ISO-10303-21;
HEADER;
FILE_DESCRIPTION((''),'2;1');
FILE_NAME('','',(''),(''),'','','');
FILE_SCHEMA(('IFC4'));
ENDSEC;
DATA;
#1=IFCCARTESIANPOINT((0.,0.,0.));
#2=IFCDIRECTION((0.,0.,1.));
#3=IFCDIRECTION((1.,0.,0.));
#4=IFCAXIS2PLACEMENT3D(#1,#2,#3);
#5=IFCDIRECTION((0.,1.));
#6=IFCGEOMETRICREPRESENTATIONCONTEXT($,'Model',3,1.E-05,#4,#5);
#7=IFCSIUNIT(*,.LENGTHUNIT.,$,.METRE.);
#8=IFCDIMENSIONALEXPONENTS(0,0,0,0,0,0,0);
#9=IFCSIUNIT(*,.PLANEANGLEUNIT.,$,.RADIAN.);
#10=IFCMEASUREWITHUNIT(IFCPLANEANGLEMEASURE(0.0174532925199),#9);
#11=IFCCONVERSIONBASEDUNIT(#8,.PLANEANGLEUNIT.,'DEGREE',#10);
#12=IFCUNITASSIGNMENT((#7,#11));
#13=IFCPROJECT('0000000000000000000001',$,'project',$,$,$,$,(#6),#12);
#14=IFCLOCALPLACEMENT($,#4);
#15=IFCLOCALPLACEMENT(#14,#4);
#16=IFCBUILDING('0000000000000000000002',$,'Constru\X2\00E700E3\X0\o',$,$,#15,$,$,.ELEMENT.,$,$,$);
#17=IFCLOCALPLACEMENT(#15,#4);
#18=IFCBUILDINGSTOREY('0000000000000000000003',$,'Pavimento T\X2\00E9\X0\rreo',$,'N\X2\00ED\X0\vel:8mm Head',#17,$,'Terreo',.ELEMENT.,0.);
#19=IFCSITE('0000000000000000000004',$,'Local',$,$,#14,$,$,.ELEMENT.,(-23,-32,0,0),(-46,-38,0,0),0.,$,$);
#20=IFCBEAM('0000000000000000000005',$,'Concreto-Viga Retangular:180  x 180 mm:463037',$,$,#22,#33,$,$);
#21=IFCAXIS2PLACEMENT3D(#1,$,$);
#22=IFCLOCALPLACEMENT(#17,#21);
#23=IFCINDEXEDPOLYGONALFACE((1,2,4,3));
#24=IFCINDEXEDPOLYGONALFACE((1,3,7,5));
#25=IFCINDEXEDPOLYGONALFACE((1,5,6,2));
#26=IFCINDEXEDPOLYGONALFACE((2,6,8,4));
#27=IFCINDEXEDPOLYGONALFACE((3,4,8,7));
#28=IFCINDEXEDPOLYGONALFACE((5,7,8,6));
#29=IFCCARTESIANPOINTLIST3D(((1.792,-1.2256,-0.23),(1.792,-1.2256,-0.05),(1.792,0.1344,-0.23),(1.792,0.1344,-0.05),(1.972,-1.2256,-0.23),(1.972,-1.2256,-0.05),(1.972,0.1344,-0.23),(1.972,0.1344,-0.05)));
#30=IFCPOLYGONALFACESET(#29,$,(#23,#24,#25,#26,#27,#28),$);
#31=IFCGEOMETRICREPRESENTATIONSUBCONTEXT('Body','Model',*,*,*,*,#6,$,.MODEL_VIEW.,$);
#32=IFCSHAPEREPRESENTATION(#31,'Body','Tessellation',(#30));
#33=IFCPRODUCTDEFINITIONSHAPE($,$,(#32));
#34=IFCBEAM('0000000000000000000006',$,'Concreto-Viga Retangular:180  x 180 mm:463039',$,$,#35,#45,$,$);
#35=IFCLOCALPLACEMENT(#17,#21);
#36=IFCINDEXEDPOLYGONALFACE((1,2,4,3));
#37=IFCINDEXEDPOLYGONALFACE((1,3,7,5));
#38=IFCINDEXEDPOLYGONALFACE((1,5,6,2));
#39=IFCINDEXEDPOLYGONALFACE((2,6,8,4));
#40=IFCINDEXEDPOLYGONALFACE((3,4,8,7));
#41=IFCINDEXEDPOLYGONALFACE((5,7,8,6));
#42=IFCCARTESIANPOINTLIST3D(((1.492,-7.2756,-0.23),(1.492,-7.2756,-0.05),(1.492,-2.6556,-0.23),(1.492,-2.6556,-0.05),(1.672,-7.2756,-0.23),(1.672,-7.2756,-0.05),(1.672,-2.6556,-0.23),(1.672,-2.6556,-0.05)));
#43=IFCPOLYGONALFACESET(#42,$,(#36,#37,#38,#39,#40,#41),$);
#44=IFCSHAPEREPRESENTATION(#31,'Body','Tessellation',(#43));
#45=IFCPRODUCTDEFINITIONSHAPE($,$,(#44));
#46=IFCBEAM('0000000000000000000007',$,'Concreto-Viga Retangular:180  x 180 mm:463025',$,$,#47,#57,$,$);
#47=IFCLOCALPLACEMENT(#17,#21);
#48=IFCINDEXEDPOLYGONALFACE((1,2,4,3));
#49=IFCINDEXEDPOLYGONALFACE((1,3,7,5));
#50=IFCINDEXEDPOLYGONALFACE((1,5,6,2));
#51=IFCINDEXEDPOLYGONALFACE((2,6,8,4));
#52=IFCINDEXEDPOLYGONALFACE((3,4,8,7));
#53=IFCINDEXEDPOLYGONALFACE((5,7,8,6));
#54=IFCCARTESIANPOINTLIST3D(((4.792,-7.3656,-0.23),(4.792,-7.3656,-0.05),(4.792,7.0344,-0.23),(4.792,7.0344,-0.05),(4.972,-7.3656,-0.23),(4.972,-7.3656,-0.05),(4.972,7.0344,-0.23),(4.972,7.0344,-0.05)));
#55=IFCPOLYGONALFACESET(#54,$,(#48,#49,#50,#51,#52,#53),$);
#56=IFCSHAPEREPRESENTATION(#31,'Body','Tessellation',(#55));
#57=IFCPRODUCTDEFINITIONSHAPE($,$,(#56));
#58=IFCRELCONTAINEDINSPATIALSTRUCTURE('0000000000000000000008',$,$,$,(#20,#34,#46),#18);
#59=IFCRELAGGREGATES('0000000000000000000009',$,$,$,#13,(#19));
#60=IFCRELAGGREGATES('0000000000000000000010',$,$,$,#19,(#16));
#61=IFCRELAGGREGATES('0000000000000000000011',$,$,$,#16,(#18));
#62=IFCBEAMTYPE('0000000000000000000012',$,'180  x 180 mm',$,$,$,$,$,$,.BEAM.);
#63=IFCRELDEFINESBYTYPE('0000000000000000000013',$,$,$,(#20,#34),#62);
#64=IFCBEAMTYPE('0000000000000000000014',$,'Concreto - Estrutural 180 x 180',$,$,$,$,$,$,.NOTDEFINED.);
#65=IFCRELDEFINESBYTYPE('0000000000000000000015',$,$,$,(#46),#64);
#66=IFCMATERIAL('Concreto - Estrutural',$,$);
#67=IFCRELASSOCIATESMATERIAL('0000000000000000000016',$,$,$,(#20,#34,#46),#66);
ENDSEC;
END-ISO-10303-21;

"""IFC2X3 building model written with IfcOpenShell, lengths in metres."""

from ifc_helpers import new_model, entity, si_unit, converted_unit, direction, frame, frame_2d, origin_with_axes, place, context, subcontext, project, spatial, rectangle, extrude, material, type_object, element, save


model = new_model("IFC2X3")

# Units and contexts
model_context = context("Model", 3, precision=1e-05, world=origin_with_axes(), true_north=direction((0.0, 1.0)))
body_context = subcontext(model_context, "Body", "Model", "MODEL_VIEW")
ifc_project = project(units=[si_unit("LENGTHUNIT", "METRE"), converted_unit("PLANEANGLEUNIT", "DEGREE", entity("IfcPlaneAngleMeasure", 0.0174532925199), si_unit("PLANEANGLEUNIT", "RADIAN"), dimensions=[0, 0, 0, 0, 0, 0, 0])], contexts=[model_context])

# Site, building, storey
site_placement = place(None, origin_with_axes())
site = spatial("IfcSite", under=ifc_project, at=site_placement, Name="Local", CompositionType="ELEMENT", RefLatitude=(-23, -32, 0, 0), RefLongitude=(-46, -38, 0, 0), RefElevation=0.0)
building_placement = place(site_placement, origin_with_axes())
building = spatial("IfcBuilding", under=site, at=building_placement, Name="Construção", CompositionType="ELEMENT")
storey_placement = place(building_placement, origin_with_axes())
storey = spatial("IfcBuildingStorey", under=building, at=storey_placement, Name="Pavimento Térreo", ObjectType="Nível:8mm Head", LongName="Terreo", CompositionType="ELEMENT", Elevation=0.0)

# Shared definitions
ifc_material = material(Name="Concreto - Estrutural")

# Beams
beam_type_1 = type_object("IfcBeamType", Name="180  x 180 mm", PredefinedType="BEAM")
beam_1_placement = place(storey_placement, frame((1.882, -1.2256, -0.05), z_axis=(0.0, 0.0, 1.0), x_axis=(1.0, 0.0, 0.0)))
element("IfcBeam", 1, at=beam_1_placement, inside=storey, type_object=beam_type_1, material=ifc_material, Name="Concreto-Viga Retangular:180  x 180 mm:463037", context=body_context, shape_type="SweptSolid", body=[
    extrude(rectangle(XDim=0.18, YDim=0.18, at=frame_2d((-0.09, 0.0), x_axis=(1.0, 0.0))), frame((0.0, 0.0, 0.0), z_axis=(0.0, 1.0, 0.0), x_axis=(0.0, 0.0, 1.0)), (0.0, 0.0, 1.0), 1.36),
])
beam_2_placement = place(storey_placement, frame((1.582, -7.2756, -0.05), z_axis=(0.0, 0.0, 1.0), x_axis=(1.0, 0.0, 0.0)))
element("IfcBeam", 2, at=beam_2_placement, inside=storey, type_object=beam_type_1, material=ifc_material, Name="Concreto-Viga Retangular:180  x 180 mm:463039", context=body_context, shape_type="SweptSolid", body=[
    extrude(rectangle(XDim=0.18, YDim=0.18, at=frame_2d((-0.09, 0.0), x_axis=(1.0, 0.0))), frame((0.0, 0.0, 0.0), z_axis=(0.0, 1.0, 0.0), x_axis=(0.0, 0.0, 1.0)), (0.0, 0.0, 1.0), 4.62),
])
beam_type_2 = type_object("IfcBeamType", Name="Concreto - Estrutural 180 x 180", PredefinedType="NOTDEFINED")
beam_3_placement = place(storey_placement, frame((4.882, -7.3656, -0.05), z_axis=(0.0, 0.0, 1.0), x_axis=(1.0, 0.0, 0.0)))
element("IfcBeam", 3, at=beam_3_placement, inside=storey, type_object=beam_type_2, material=ifc_material, Name="Concreto-Viga Retangular:180  x 180 mm:463025", context=body_context, shape_type="SweptSolid", body=[
    extrude(rectangle(XDim=0.18, YDim=0.18, at=frame_2d((-0.09, 0.0), x_axis=(1.0, 0.0))), frame((0.0, 0.0, 0.0), z_axis=(0.0, 1.0, 0.0), x_axis=(0.0, 0.0, 1.0)), (0.0, 0.0, 1.0), 14.4),
])

save(model, "model.ifc")
